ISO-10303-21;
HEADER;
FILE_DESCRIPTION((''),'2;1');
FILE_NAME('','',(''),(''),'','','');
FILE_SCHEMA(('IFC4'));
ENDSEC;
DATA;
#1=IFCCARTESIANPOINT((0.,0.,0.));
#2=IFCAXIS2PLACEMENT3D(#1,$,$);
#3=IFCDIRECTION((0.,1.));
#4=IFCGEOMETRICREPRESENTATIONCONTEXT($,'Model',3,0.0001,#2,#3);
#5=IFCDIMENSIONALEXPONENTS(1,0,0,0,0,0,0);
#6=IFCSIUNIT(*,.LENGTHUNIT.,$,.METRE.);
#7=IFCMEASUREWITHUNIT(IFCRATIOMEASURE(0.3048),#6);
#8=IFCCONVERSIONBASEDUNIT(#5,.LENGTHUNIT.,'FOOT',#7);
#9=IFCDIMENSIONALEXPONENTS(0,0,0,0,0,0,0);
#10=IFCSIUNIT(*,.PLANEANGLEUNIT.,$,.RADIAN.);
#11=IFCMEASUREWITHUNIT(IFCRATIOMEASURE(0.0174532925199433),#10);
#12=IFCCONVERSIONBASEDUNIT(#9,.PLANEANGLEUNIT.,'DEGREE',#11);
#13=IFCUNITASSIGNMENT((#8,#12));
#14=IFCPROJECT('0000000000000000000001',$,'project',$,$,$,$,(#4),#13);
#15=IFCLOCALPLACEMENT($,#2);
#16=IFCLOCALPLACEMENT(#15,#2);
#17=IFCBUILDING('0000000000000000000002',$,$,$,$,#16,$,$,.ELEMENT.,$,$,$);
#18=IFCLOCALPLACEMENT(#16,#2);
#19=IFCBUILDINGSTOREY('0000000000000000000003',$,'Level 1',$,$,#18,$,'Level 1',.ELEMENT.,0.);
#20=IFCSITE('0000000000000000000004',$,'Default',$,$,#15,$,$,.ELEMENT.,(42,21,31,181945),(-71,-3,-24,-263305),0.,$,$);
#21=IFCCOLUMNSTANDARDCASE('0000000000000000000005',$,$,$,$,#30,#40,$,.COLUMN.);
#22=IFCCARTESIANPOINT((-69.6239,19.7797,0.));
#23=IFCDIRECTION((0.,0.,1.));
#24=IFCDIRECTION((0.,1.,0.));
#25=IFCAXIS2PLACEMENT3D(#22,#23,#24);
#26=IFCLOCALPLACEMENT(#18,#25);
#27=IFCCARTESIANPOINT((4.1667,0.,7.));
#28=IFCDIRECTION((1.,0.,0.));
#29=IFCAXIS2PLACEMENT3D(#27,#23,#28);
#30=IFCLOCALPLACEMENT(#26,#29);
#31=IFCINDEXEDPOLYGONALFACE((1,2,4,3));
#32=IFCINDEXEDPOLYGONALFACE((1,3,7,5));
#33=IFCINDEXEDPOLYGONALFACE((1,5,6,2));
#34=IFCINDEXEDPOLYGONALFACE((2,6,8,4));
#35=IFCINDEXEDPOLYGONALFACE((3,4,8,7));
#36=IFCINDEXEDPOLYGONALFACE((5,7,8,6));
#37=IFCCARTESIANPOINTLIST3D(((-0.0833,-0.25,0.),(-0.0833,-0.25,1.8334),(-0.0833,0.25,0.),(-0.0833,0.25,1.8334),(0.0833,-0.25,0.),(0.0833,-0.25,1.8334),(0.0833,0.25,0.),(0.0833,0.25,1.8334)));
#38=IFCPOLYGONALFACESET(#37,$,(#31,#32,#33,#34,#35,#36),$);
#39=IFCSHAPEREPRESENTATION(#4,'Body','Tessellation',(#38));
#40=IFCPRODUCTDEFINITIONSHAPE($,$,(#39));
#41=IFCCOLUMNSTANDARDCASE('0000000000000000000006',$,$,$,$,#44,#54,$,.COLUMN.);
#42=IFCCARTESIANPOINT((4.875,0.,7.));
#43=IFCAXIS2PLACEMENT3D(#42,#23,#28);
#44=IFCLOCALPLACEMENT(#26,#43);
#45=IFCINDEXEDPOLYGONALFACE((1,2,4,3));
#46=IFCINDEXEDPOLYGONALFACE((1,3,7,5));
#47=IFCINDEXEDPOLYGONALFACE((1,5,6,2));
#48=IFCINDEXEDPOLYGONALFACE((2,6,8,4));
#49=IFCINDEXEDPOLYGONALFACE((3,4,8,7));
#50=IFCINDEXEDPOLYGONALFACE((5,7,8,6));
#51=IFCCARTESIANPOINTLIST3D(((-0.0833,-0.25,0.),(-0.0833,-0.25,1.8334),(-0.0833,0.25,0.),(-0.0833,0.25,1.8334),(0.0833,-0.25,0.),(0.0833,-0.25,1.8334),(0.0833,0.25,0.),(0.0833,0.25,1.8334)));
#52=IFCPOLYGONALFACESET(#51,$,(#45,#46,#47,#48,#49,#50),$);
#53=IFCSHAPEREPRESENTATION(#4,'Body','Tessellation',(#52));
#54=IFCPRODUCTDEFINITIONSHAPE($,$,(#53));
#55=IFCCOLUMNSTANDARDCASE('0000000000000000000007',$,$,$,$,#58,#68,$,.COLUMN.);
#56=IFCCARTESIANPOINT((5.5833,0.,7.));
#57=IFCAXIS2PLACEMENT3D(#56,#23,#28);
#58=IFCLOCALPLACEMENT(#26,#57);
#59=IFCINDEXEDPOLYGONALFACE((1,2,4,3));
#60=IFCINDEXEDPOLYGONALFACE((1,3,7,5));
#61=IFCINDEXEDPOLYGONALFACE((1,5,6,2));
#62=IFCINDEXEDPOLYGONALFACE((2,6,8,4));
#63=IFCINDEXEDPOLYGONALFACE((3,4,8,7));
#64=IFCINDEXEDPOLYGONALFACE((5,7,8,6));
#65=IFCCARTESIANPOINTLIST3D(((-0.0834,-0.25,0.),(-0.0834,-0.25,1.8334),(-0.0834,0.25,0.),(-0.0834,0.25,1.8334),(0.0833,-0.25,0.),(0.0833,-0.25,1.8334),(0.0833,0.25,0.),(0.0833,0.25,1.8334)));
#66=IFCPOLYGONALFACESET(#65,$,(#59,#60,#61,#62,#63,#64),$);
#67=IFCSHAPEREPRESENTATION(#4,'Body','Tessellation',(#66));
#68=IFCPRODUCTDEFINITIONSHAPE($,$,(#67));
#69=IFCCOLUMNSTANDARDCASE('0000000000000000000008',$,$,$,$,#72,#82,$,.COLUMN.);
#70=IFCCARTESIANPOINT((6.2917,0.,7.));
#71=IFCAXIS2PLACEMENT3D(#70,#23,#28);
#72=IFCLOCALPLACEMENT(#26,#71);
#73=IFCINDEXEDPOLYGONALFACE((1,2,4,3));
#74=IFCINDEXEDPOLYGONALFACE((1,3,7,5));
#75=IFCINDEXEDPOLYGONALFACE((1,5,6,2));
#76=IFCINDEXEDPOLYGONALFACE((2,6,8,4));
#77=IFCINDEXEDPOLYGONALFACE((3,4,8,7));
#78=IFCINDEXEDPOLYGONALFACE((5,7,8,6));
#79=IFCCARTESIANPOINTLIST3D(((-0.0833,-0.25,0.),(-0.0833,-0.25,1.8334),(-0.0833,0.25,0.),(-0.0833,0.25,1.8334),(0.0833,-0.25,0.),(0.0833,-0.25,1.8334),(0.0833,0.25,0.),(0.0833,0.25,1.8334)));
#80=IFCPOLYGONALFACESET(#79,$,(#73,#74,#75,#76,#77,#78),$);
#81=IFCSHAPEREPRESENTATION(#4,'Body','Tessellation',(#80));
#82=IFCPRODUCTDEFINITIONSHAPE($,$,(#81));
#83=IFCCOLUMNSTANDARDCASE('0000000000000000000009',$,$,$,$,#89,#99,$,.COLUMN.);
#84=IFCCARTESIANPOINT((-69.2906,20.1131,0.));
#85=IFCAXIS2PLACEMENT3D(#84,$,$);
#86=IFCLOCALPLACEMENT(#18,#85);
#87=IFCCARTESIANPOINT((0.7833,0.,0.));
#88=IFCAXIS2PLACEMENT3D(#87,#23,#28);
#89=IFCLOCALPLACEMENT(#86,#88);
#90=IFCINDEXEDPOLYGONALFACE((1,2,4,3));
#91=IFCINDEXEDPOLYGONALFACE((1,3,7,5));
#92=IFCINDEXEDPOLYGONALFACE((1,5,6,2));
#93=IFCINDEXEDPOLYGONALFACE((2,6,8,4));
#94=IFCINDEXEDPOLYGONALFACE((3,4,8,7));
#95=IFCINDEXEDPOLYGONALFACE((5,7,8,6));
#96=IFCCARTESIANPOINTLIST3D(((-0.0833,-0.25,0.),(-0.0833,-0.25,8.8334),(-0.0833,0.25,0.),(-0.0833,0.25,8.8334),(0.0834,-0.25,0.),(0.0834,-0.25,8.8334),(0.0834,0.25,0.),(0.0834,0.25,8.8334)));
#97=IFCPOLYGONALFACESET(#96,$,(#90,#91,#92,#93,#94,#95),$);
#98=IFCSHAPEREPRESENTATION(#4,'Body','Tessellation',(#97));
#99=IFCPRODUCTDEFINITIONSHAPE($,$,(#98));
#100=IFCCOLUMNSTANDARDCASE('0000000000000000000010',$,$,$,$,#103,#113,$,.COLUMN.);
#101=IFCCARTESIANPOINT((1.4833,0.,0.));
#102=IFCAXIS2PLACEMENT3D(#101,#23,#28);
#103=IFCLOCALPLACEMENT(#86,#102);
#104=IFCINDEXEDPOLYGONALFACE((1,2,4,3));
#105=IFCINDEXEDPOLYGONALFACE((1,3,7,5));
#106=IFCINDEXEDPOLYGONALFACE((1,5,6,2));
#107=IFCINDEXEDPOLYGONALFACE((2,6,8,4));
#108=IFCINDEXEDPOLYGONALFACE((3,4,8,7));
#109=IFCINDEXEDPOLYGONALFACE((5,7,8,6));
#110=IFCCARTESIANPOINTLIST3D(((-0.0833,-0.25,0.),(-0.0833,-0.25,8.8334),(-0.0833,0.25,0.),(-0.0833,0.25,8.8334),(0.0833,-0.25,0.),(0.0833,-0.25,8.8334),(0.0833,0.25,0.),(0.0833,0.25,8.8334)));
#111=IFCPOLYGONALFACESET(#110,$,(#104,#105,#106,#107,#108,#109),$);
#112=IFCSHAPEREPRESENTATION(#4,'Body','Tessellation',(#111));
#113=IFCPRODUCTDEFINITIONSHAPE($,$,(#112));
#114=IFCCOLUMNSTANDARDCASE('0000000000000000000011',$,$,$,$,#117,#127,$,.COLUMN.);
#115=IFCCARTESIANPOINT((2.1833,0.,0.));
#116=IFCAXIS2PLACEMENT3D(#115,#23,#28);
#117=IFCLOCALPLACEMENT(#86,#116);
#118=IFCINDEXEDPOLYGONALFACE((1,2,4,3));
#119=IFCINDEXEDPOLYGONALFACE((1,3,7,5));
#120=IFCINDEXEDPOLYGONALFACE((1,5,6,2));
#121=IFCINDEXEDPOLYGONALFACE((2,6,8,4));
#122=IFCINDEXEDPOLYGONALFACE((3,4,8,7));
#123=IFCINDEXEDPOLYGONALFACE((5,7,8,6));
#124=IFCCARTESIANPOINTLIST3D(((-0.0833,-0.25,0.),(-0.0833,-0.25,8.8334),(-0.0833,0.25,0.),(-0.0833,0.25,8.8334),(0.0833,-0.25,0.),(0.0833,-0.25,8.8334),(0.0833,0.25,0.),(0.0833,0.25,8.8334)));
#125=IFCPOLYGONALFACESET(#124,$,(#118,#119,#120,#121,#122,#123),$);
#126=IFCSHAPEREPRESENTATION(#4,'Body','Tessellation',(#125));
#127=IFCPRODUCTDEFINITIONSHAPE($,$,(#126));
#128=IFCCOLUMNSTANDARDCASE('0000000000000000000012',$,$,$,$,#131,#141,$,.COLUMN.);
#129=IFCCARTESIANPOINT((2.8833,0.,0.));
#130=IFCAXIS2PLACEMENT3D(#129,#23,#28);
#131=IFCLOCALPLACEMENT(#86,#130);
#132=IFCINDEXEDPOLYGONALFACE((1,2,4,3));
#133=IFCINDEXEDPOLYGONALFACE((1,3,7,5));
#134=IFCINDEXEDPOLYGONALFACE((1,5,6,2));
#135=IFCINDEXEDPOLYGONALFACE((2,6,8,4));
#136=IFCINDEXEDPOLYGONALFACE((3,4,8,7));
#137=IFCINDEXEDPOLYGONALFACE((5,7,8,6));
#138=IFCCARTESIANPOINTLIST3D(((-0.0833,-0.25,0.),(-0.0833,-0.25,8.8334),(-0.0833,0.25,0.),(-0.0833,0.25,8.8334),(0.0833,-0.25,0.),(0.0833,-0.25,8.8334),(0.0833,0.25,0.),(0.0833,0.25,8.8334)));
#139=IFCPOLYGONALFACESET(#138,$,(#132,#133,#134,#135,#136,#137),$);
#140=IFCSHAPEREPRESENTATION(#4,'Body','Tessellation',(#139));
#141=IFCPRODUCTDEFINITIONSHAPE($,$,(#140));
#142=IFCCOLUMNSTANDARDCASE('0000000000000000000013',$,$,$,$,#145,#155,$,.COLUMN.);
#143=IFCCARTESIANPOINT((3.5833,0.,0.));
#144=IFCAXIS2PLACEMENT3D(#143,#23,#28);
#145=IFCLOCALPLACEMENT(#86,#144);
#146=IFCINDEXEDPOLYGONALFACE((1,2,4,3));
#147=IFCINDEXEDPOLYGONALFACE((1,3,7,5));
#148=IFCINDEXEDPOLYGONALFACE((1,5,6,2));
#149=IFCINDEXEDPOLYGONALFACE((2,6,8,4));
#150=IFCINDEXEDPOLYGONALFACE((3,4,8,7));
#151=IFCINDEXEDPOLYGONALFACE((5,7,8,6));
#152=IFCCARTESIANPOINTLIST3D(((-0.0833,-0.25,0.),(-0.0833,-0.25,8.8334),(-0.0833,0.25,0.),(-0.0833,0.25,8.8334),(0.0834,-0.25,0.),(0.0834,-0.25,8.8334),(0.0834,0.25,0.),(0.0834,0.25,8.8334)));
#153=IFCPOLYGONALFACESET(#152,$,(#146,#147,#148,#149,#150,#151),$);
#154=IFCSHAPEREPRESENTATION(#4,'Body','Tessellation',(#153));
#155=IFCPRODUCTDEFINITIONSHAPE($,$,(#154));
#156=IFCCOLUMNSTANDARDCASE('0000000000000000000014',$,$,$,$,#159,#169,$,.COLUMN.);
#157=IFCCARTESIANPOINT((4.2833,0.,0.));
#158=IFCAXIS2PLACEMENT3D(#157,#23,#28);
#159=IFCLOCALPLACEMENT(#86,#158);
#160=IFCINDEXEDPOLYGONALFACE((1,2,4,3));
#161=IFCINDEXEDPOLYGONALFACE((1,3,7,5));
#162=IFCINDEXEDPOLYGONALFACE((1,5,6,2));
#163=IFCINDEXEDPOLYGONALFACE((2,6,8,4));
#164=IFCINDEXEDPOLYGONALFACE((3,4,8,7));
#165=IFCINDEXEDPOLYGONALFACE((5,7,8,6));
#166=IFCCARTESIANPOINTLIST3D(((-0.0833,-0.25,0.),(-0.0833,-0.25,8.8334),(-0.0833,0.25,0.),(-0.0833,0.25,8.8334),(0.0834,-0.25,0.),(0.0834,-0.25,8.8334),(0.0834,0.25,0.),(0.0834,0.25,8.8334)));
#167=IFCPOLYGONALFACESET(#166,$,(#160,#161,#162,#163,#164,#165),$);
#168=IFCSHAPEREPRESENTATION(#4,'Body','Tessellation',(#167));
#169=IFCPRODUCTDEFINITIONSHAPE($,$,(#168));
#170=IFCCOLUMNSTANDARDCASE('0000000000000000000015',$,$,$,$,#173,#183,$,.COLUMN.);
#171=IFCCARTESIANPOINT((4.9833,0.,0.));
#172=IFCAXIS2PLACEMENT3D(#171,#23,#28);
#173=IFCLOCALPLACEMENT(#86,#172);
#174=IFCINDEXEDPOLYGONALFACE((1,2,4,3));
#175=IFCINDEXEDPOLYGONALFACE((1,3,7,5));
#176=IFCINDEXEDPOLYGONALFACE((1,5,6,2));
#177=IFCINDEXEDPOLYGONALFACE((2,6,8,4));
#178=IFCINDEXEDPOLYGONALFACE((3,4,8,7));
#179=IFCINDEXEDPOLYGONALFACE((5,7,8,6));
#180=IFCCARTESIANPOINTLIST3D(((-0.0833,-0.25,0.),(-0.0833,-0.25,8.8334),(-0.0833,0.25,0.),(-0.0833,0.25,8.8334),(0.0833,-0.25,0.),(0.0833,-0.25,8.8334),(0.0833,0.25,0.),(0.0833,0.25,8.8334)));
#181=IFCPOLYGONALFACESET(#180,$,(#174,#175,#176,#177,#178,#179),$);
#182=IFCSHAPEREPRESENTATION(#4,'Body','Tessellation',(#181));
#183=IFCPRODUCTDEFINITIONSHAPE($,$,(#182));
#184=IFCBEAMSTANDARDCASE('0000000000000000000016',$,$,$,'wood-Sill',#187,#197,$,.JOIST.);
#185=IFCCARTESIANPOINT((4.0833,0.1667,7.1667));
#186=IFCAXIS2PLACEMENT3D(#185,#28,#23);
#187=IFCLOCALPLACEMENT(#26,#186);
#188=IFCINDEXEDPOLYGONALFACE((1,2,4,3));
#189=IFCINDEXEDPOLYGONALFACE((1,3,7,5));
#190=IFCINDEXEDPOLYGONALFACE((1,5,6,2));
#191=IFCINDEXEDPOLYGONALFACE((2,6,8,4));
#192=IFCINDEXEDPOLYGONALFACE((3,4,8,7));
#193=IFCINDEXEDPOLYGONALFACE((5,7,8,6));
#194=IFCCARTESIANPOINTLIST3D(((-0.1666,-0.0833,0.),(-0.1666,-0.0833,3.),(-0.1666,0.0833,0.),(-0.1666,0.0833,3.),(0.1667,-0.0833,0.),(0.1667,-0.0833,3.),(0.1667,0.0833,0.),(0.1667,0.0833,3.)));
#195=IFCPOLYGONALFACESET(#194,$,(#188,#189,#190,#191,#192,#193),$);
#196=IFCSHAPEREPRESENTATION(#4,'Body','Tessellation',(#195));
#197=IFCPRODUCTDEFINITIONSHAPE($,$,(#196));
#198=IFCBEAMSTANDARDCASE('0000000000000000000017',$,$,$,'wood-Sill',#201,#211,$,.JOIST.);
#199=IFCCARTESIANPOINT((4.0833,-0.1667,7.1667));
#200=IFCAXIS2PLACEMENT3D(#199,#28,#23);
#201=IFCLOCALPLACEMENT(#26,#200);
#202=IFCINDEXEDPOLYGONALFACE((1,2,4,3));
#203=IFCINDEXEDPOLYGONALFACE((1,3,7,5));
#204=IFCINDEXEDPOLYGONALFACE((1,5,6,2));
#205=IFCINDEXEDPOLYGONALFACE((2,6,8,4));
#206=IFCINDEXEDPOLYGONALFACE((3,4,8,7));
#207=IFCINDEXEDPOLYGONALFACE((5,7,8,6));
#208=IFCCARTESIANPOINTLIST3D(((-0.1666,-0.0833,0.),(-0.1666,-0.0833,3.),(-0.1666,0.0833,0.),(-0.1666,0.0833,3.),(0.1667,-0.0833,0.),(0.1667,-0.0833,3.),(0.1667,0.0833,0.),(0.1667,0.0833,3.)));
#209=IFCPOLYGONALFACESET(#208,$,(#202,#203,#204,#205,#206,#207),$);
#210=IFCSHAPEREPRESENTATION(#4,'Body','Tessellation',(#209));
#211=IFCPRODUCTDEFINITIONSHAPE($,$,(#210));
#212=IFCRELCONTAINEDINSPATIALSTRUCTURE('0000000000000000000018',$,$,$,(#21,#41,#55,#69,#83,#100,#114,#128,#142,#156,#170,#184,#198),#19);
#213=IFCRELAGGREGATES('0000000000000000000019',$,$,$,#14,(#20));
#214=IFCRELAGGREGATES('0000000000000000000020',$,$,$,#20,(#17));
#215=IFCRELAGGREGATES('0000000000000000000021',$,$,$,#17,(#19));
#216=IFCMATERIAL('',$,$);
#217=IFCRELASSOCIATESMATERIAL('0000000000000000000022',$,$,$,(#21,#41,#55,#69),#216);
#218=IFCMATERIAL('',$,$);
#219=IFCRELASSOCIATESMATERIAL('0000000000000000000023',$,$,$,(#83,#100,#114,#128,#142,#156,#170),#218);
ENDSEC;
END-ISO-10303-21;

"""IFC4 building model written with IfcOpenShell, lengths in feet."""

from ifc_helpers import new_model, entity, si_unit, converted_unit, direction, frame, origin, origin_with_axes, place, context, project, spatial, rectangle, extrude, material, element, save


model = new_model("IFC4")

# Units and contexts
model_context = context("Model", 3, precision=0.0001, world=origin(), true_north=direction((0.0, 1.0)))
ifc_project = project(units=[converted_unit("LENGTHUNIT", "FOOT", entity("IfcRatioMeasure", 0.3048), si_unit("LENGTHUNIT", "METRE"), dimensions=[1, 0, 0, 0, 0, 0, 0]), converted_unit("PLANEANGLEUNIT", "DEGREE", entity("IfcRatioMeasure", 0.0174532925199433), si_unit("PLANEANGLEUNIT", "RADIAN"), dimensions=[0, 0, 0, 0, 0, 0, 0])], contexts=[model_context])

# Site, building, storey
site_placement = place(None, origin())
site = spatial("IfcSite", under=ifc_project, at=site_placement, Name="Default", CompositionType="ELEMENT", RefLatitude=(42, 21, 31, 181945), RefLongitude=(-71, -3, -24, -263305), RefElevation=0.0)
building_placement = place(site_placement, origin())
building = spatial("IfcBuilding", under=site, at=building_placement, CompositionType="ELEMENT")
storey_placement = place(building_placement, origin())
storey = spatial("IfcBuildingStorey", under=building, at=storey_placement, Name="Level 1", LongName="Level 1", CompositionType="ELEMENT", Elevation=0.0)

# Columns
ifc_material_1 = material(Name="")
placement_1 = place(storey_placement, frame((-69.6239, 19.7797, 0.0), z_axis=(0.0, 0.0, 1.0), x_axis=(0.0, 1.0, 0.0)))
ifc_material_2 = material(Name="")
for number, where, z_axis, x_axis in (
    (1, (4.1667, 0.0, 7.0), (0.0, 0.0, 1.0), (1.0, 0.0, 0.0)),
    (2, (4.875, 0.0, 7.0), (0.0, 0.0, 1.0), (1.0, 0.0, 0.0)),
    (3, (5.5833, 0.0, 7.0), (0.0, 0.0, 1.0), (1.0, 0.0, 0.0)),
    (4, (6.2917, 0.0, 7.0), (0.0, 0.0, 1.0), (1.0, 0.0, 0.0)),
):
    element("IfcColumnStandardCase", number, at=place(placement_1, frame(where, z_axis=z_axis, x_axis=x_axis)), inside=storey, material=ifc_material_2, PredefinedType="COLUMN", context=model_context, shape_type="SweptSolid", body=[
        extrude(rectangle(XDim=0.1667, YDim=0.5), origin(), (0.0, 0.0, 1.0), 1.8334),
    ])
placement_2 = place(storey_placement, frame((-69.2906, 20.1131, 0.0)))
for number, where, z_axis, x_axis in (
    (5, (0.7833, 0.0, 0.0), (0.0, 0.0, 1.0), (1.0, 0.0, 0.0)),
    (6, (1.4833, 0.0, 0.0), (0.0, 0.0, 1.0), (1.0, 0.0, 0.0)),
    (7, (2.1833, 0.0, 0.0), (0.0, 0.0, 1.0), (1.0, 0.0, 0.0)),
    (8, (2.8833, 0.0, 0.0), (0.0, 0.0, 1.0), (1.0, 0.0, 0.0)),
    (9, (3.5833, 0.0, 0.0), (0.0, 0.0, 1.0), (1.0, 0.0, 0.0)),
    (10, (4.2833, 0.0, 0.0), (0.0, 0.0, 1.0), (1.0, 0.0, 0.0)),
    (11, (4.9833, 0.0, 0.0), (0.0, 0.0, 1.0), (1.0, 0.0, 0.0)),
):
    element("IfcColumnStandardCase", number, at=place(placement_2, frame(where, z_axis=z_axis, x_axis=x_axis)), inside=storey, material=ifc_material_1, PredefinedType="COLUMN", context=model_context, shape_type="SweptSolid", body=[
        extrude(rectangle(XDim=0.1667, YDim=0.5), origin(), (0.0, 0.0, 1.0), 8.8334),
    ])

# Beams
for number, where, z_axis, x_axis in (
    (12, (4.0833, 0.1667, 7.1667), (1.0, 0.0, 0.0), (0.0, 0.0, 1.0)),
    (13, (4.0833, -0.1667, 7.1667), (1.0, 0.0, 0.0), (0.0, 0.0, 1.0)),
):
    element("IfcBeamStandardCase", number, at=place(placement_1, frame(where, z_axis=z_axis, x_axis=x_axis)), inside=storey, ObjectType="wood-Sill", PredefinedType="JOIST", context=model_context, shape_type="SweptSolid", body=[
        extrude(rectangle(XDim=0.3333, YDim=0.1667), origin_with_axes(), (0.0, 0.0, 1.0), 3.0),
    ])

save(model, "model.ifc")
